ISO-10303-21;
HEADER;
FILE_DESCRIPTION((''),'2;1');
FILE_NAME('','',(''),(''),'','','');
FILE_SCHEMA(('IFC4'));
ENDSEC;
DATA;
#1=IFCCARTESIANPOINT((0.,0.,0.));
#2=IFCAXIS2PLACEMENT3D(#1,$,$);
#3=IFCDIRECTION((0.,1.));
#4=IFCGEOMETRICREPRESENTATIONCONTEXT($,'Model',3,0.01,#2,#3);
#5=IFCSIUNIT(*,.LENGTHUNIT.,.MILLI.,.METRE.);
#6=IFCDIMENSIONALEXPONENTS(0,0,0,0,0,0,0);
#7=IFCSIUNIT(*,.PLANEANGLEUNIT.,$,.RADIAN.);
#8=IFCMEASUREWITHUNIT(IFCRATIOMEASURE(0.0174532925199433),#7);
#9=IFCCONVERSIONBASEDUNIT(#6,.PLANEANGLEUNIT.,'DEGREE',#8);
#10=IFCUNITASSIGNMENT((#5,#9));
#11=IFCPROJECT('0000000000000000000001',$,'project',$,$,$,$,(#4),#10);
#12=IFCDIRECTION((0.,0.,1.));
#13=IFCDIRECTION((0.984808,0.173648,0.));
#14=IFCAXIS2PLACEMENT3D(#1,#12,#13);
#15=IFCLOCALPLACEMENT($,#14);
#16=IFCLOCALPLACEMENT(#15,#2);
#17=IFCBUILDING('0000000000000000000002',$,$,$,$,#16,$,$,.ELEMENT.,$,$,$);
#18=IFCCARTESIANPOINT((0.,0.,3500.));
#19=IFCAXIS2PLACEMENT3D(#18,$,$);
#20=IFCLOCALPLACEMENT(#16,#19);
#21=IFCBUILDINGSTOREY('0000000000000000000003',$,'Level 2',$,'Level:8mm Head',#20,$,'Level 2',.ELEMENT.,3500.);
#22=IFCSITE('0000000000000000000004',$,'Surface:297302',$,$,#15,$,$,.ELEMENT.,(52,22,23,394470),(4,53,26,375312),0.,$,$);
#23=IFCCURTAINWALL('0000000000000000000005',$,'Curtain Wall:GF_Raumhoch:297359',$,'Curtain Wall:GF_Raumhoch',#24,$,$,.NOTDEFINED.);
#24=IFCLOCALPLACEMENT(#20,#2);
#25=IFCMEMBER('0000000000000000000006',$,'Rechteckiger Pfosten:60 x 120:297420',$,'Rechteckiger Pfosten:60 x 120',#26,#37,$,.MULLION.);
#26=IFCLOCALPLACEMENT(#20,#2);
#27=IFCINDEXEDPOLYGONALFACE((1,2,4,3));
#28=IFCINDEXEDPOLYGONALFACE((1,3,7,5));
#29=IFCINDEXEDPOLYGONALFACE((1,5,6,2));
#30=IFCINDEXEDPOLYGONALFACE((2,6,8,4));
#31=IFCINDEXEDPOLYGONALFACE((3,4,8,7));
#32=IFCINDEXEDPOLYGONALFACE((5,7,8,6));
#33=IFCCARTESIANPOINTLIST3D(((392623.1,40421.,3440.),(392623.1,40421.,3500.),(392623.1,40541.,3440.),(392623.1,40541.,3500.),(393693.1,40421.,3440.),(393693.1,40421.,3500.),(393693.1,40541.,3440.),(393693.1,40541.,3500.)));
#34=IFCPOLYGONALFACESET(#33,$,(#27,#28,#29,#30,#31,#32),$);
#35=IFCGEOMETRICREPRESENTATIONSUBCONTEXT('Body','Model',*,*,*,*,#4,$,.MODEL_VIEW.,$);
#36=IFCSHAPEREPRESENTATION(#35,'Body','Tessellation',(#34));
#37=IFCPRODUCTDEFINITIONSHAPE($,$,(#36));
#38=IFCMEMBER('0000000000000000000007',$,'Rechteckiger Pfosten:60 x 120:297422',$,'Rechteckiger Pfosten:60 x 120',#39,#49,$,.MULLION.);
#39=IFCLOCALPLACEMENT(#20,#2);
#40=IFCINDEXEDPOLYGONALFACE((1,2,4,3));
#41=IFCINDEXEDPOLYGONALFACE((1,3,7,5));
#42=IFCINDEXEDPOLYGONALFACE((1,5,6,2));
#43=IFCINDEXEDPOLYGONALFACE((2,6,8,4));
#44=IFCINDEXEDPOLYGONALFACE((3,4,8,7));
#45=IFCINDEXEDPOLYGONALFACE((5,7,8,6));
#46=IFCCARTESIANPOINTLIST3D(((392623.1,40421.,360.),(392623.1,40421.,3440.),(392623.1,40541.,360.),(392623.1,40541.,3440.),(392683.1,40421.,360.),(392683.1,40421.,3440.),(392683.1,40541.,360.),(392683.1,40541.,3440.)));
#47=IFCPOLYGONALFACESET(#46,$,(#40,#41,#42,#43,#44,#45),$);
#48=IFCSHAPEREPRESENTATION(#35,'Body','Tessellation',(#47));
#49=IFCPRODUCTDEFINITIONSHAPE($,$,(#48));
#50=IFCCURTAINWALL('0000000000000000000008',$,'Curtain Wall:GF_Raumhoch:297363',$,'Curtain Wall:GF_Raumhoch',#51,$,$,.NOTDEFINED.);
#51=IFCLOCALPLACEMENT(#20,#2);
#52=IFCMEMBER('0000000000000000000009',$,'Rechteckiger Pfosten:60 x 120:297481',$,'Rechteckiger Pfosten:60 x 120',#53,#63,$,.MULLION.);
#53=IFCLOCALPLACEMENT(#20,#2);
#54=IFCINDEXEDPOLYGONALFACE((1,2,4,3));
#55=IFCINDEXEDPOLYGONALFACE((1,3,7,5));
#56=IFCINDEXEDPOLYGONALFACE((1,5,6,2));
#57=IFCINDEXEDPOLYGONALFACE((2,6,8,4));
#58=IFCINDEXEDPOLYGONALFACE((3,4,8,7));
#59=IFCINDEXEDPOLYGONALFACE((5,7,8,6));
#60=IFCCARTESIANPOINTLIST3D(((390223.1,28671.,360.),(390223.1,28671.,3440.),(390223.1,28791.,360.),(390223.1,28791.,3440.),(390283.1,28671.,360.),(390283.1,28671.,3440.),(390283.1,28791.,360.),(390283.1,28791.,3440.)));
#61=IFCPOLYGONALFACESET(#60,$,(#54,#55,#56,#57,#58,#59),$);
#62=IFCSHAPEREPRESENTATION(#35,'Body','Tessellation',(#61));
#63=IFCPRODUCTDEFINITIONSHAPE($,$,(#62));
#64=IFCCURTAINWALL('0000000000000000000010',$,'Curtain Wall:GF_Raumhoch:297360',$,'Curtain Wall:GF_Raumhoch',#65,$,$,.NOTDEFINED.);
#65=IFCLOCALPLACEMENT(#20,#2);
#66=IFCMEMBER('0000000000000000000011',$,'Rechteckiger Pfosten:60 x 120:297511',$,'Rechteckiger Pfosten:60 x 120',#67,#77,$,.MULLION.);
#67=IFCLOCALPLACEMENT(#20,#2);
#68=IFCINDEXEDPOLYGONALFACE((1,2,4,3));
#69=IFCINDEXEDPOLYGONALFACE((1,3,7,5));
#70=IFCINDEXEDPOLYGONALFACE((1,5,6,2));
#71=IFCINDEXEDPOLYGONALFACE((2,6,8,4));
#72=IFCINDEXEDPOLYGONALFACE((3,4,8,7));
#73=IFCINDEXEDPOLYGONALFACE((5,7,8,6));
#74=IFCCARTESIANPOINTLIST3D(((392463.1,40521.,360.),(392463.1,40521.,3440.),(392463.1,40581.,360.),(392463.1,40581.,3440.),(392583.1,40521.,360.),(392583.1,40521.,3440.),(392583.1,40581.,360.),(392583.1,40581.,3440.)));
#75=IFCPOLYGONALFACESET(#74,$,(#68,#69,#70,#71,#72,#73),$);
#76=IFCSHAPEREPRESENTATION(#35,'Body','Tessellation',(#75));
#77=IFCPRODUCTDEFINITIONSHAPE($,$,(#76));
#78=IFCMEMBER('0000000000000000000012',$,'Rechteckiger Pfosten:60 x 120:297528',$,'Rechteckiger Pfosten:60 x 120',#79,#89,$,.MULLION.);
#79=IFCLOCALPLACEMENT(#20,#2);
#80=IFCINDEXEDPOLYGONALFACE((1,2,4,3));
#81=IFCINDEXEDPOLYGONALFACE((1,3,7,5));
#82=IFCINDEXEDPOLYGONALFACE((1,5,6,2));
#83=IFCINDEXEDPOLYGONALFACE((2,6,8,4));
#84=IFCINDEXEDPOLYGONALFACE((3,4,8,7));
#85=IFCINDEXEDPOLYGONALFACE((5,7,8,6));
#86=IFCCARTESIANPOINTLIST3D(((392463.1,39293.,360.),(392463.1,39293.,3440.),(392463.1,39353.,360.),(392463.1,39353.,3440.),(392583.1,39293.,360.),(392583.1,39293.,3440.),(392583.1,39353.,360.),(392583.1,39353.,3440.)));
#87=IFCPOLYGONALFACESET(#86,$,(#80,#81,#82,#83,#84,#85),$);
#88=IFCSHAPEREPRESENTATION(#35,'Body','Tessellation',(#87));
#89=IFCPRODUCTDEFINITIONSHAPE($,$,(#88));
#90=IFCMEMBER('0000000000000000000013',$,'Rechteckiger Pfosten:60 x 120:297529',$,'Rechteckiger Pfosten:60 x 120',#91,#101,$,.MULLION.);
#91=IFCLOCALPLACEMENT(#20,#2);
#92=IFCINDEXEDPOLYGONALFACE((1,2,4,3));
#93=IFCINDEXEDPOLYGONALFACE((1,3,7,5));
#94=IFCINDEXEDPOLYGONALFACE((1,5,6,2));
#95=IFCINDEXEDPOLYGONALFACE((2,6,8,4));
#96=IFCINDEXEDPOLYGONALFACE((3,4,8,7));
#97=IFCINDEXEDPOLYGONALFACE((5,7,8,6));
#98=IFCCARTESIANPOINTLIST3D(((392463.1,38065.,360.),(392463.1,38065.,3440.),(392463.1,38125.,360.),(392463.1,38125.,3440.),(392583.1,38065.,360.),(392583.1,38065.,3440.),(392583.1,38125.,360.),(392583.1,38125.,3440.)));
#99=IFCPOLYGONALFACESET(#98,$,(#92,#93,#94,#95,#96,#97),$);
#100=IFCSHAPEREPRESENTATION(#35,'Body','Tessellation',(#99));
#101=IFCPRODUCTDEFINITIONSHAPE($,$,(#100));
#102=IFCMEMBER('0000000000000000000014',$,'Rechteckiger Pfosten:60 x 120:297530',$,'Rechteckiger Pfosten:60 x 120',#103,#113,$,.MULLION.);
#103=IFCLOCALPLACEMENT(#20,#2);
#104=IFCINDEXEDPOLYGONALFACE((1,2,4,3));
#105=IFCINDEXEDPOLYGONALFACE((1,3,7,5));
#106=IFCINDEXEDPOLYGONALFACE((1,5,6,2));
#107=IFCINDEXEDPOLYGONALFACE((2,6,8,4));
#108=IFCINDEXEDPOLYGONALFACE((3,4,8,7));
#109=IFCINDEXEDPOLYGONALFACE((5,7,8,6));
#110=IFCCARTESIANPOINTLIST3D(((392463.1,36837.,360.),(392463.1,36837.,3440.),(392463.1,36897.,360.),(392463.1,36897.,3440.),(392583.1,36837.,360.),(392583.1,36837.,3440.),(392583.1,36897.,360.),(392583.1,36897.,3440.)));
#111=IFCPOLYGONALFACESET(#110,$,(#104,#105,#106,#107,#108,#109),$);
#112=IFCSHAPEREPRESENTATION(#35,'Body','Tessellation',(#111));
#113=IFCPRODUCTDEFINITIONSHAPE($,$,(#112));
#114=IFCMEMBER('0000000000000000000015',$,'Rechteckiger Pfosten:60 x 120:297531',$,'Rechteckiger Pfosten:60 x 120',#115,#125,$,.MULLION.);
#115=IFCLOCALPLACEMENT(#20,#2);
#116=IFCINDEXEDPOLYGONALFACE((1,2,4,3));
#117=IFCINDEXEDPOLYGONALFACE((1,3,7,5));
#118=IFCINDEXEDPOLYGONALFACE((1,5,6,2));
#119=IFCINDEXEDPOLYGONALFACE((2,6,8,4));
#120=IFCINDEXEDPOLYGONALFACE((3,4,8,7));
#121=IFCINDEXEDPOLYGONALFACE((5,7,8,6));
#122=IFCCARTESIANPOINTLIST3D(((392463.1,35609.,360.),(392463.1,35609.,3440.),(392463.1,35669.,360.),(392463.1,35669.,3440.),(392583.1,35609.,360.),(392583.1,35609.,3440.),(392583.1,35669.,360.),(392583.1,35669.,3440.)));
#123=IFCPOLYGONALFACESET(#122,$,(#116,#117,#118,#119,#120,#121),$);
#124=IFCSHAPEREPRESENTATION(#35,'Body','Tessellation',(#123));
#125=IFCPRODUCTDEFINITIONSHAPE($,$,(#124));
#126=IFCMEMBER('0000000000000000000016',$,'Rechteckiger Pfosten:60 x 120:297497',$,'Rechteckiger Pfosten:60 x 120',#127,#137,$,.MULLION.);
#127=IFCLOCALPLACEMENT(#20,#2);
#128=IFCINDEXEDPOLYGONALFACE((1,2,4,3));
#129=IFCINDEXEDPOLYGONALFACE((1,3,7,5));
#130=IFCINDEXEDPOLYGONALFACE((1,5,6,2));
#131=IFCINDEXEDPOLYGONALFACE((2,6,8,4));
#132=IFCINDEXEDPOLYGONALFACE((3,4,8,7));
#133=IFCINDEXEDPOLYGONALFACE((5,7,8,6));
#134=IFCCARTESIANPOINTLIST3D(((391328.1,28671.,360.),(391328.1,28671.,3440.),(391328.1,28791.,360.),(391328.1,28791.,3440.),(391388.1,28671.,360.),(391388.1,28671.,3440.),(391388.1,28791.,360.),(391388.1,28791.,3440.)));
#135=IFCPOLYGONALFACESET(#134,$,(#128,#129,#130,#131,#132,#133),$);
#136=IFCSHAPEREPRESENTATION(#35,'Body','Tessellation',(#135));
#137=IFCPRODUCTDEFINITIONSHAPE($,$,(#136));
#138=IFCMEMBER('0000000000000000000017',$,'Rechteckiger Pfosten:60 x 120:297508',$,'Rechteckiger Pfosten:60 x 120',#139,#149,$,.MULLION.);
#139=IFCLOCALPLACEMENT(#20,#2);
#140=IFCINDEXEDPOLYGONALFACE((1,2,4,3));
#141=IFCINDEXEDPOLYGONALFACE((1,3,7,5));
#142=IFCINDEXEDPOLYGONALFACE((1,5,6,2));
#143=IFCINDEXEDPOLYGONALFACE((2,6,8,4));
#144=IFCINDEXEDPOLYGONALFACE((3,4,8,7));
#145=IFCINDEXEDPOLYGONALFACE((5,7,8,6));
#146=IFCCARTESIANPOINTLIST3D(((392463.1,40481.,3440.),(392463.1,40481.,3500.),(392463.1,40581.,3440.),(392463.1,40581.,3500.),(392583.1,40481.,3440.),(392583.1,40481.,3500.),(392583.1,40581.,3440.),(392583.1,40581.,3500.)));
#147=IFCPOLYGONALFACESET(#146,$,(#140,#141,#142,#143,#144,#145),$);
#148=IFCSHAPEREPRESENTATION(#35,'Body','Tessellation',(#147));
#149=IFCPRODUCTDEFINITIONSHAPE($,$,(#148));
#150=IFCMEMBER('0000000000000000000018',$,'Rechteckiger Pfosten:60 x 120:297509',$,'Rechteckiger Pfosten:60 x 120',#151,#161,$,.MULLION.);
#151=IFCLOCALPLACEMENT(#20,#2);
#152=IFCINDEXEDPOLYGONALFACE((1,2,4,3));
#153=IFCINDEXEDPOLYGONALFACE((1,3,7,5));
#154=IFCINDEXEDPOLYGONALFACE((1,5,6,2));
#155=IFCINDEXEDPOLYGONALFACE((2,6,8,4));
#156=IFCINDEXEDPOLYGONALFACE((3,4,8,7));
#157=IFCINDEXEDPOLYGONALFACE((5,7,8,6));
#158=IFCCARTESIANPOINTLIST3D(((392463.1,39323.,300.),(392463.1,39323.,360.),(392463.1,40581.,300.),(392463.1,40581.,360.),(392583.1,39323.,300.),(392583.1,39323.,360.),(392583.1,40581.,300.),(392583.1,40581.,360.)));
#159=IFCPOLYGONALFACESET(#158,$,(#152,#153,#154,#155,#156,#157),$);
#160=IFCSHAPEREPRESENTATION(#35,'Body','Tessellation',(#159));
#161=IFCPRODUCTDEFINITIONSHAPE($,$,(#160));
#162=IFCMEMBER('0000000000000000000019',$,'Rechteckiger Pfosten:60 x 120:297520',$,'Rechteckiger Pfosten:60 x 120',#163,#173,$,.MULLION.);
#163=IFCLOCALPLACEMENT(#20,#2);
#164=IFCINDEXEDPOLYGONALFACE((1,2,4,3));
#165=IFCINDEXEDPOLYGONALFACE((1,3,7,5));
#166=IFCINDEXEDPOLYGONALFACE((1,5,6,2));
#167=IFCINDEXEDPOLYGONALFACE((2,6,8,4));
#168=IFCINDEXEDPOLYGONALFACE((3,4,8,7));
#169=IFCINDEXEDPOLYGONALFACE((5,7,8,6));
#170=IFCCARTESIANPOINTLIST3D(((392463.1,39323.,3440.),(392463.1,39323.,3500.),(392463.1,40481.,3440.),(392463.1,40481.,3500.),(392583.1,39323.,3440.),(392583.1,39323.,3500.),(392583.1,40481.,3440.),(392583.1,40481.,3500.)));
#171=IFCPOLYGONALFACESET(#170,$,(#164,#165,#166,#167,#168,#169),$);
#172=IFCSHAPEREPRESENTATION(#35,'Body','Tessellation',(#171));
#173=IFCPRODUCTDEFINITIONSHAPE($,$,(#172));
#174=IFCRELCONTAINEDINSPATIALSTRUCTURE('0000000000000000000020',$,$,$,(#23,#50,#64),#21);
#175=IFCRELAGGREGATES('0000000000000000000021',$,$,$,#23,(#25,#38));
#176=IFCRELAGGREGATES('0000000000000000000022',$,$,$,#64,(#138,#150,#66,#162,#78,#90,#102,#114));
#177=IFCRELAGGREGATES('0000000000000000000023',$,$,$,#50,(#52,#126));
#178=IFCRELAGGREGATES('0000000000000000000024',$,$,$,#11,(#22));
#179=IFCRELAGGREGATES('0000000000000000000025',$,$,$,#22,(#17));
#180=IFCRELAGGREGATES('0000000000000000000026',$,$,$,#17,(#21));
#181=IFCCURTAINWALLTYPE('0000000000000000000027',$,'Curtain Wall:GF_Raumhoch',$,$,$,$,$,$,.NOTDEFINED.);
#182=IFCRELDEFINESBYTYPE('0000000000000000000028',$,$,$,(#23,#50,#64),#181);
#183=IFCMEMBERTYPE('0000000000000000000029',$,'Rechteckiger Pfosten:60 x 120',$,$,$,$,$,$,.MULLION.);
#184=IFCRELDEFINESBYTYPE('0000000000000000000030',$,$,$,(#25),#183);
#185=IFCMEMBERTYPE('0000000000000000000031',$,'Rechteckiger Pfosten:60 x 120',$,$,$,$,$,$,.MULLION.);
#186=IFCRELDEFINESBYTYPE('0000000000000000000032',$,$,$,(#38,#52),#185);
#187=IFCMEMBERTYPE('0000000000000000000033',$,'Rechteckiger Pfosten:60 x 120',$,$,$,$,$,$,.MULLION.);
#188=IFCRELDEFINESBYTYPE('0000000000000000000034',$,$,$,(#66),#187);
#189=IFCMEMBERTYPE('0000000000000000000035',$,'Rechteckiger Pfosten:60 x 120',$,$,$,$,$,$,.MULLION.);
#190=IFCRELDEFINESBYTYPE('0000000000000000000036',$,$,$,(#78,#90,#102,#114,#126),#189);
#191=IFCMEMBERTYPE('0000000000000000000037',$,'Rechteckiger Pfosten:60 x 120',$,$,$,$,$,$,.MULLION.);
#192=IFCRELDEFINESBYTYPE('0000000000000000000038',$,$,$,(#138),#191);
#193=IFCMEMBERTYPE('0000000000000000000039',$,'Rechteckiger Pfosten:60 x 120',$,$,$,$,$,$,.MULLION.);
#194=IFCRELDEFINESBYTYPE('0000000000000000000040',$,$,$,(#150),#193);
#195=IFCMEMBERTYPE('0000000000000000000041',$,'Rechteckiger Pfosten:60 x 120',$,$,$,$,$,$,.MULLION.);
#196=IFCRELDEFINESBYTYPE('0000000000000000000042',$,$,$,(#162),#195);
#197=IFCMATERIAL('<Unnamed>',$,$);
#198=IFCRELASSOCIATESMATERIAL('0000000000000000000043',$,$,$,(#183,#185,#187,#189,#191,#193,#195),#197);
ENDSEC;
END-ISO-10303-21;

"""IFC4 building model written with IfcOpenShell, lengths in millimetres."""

from ifc_helpers import new_model, entity, si_unit, converted_unit, direction, frame, origin, place, context, subcontext, project, spatial, indexed_curve, outline, extrude, source, transform, mapped, material, type_object, type_shapes, element, aggregate, save


model = new_model("IFC4")

# Units and contexts
model_context = context("Model", 3, precision=0.01, world=origin(), true_north=direction((0.0, 1.0)))
body_context = subcontext(model_context, "Body", "Model", "MODEL_VIEW")
ifc_project = project(units=[si_unit("LENGTHUNIT", "METRE", prefix="MILLI"), converted_unit("PLANEANGLEUNIT", "DEGREE", entity("IfcRatioMeasure", 0.0174532925199433), si_unit("PLANEANGLEUNIT", "RADIAN"), dimensions=[0, 0, 0, 0, 0, 0, 0])], contexts=[model_context])

# Site, building, storey
site_placement = place(None, frame((0.0, 0.0, 0.0), z_axis=(0.0, 0.0, 1.0), x_axis=(0.984808, 0.173648, 0.0)))
site = spatial("IfcSite", under=ifc_project, at=site_placement, Name="Surface:297302", CompositionType="ELEMENT", RefLatitude=(52, 22, 23, 394470), RefLongitude=(4, 53, 26, 375312), RefElevation=0.0)
building_placement = place(site_placement, origin())
building = spatial("IfcBuilding", under=site, at=building_placement, CompositionType="ELEMENT")
storey_placement = place(building_placement, frame((0.0, 0.0, 3500.0)))
storey = spatial("IfcBuildingStorey", under=building, at=storey_placement, Name="Level 2", ObjectType="Level:8mm Head", LongName="Level 2", CompositionType="ELEMENT", Elevation=3500.0)

# Curtain wall, members
curtain_wall_type = type_object("IfcCurtainWallType", Name="Curtain Wall:GF_Raumhoch", PredefinedType="NOTDEFINED")
curtain_wall_1_placement = place(storey_placement, frame((0.0, 0.0, -3500.0)))
curtain_wall_1 = element("IfcCurtainWall", 1, at=curtain_wall_1_placement, inside=storey, type_object=curtain_wall_type, Name="Curtain Wall:GF_Raumhoch:297359", ObjectType="Curtain Wall:GF_Raumhoch", PredefinedType="NOTDEFINED")
ifc_material_1 = material(Name="<Unnamed>")
member_type_1 = type_object("IfcMemberType", Name="Rechteckiger Pfosten:60 x 120", PredefinedType="MULLION", material=ifc_material_1)
shared_shape_1 = source(origin(), body_context, "Body", "SweptSolid", [
    extrude(outline(indexed_curve([(-60.0, -30.0), (60.0, -30.0), (60.0, 30.0), (-60.0, 30.0), (-60.0, -30.0)], self_intersect=False)), frame((-30.0, 0.0, -1070.0), z_axis=(0.0, 0.0, 1.0), x_axis=(0.0, -1.0, 0.0)), (0.0, 0.0, 1.0), 1070.0),
])
type_shapes(member_type_1, [shared_shape_1])
member_1_placement = place(curtain_wall_1_placement, frame((392623.1, 40481.0, 7000.0), z_axis=(-1.0, 0.0, 0.0), x_axis=(0.0, 0.0, 1.0)))
member_1 = element("IfcMember", 2, at=member_1_placement, type_object=member_type_1, Name="Rechteckiger Pfosten:60 x 120:297420", ObjectType="Rechteckiger Pfosten:60 x 120", PredefinedType="MULLION", context=body_context, shape_type="MappedRepresentation", body=[
    mapped(shared_shape_1, transform((0.0, 0.0, 0.0), scale=1.0)),
])
member_type_2 = type_object("IfcMemberType", Name="Rechteckiger Pfosten:60 x 120", PredefinedType="MULLION", material=ifc_material_1)
shared_shape_2 = source(origin(), body_context, "Body", "SweptSolid", [
    extrude(outline(indexed_curve([(-60.0, -30.0), (60.0, -30.0), (60.0, 30.0), (-60.0, 30.0), (-60.0, -30.0)], self_intersect=False)), frame((-30.0, 0.0, -3080.0), z_axis=(0.0, 0.0, 1.0), x_axis=(0.0, -1.0, 0.0)), (0.0, 0.0, 1.0), 3080.0),
])
type_shapes(member_type_2, [shared_shape_2])
member_2_placement = place(curtain_wall_1_placement, frame((392623.1, 40481.0, 3860.0), z_axis=(0.0, 0.0, -1.0), x_axis=(-1.0, 0.0, 0.0)))
member_2 = element("IfcMember", 3, at=member_2_placement, type_object=member_type_2, Name="Rechteckiger Pfosten:60 x 120:297422", ObjectType="Rechteckiger Pfosten:60 x 120", PredefinedType="MULLION", context=body_context, shape_type="MappedRepresentation", body=[
    mapped(shared_shape_2, transform((0.0, 0.0, 0.0), scale=1.0)),
])

# Curtain wall, member
curtain_wall_2_placement = place(storey_placement, frame((0.0, 0.0, -3500.0)))
curtain_wall_2 = element("IfcCurtainWall", 4, at=curtain_wall_2_placement, inside=storey, type_object=curtain_wall_type, Name="Curtain Wall:GF_Raumhoch:297363", ObjectType="Curtain Wall:GF_Raumhoch", PredefinedType="NOTDEFINED")
member_3_placement = place(curtain_wall_2_placement, frame((390223.1, 28731.0, 3860.0), z_axis=(0.0, 0.0, -1.0), x_axis=(-1.0, 0.0, 0.0)))
member_3 = element("IfcMember", 5, at=member_3_placement, type_object=member_type_2, Name="Rechteckiger Pfosten:60 x 120:297481", ObjectType="Rechteckiger Pfosten:60 x 120", PredefinedType="MULLION", context=body_context, shape_type="MappedRepresentation", body=[
    mapped(shared_shape_2, transform((0.0, 0.0, 0.0), scale=1.0)),
])

# Curtain wall, members
curtain_wall_3_placement = place(storey_placement, frame((0.0, 0.0, -3500.0)))
curtain_wall_3 = element("IfcCurtainWall", 6, at=curtain_wall_3_placement, inside=storey, type_object=curtain_wall_type, Name="Curtain Wall:GF_Raumhoch:297360", ObjectType="Curtain Wall:GF_Raumhoch", PredefinedType="NOTDEFINED")
member_type_3 = type_object("IfcMemberType", Name="Rechteckiger Pfosten:60 x 120", PredefinedType="MULLION", material=ifc_material_1)
shared_shape_3 = source(origin(), body_context, "Body", "SweptSolid", [
    extrude(outline(indexed_curve([(-60.0, -30.0), (60.0, -30.0), (60.0, 30.0), (-60.0, 30.0), (-60.0, -30.0)], self_intersect=False)), frame((-30.0, 0.0, -3080.0), z_axis=(0.0, 0.0, 1.0), x_axis=(0.0, -1.0, 0.0)), (0.0, 0.0, 1.0), 3080.0),
])
type_shapes(member_type_3, [shared_shape_3])
member_4_placement = place(curtain_wall_3_placement, frame((392523.1, 40581.0, 6940.0), z_axis=(0.0, 0.0, 1.0), x_axis=(0.0, 1.0, 0.0)))
member_4 = element("IfcMember", 7, at=member_4_placement, type_object=member_type_3, Name="Rechteckiger Pfosten:60 x 120:297511", ObjectType="Rechteckiger Pfosten:60 x 120", PredefinedType="MULLION", context=body_context, shape_type="MappedRepresentation", body=[
    mapped(shared_shape_3, transform((0.0, 0.0, 0.0), scale=1.0)),
])
member_type_4 = type_object("IfcMemberType", Name="Rechteckiger Pfosten:60 x 120", PredefinedType="MULLION", material=ifc_material_1)
shared_shape_4 = source(origin(), body_context, "Body", "SweptSolid", [
    extrude(outline(indexed_curve([(-60.0, -30.0), (60.0, -30.0), (60.0, 30.0), (-60.0, 30.0), (-60.0, -30.0)], self_intersect=False)), frame((0.0, 0.0, -3080.0), z_axis=(0.0, 0.0, 1.0), x_axis=(0.0, -1.0, 0.0)), (0.0, 0.0, 1.0), 3080.0),
])
type_shapes(member_type_4, [shared_shape_4])
member_5_placement = place(curtain_wall_3_placement, frame((392523.1, 39323.0, 3860.0), z_axis=(0.0, 0.0, -1.0), x_axis=(0.0, -1.0, 0.0)))
member_5 = element("IfcMember", 8, at=member_5_placement, type_object=member_type_4, Name="Rechteckiger Pfosten:60 x 120:297528", ObjectType="Rechteckiger Pfosten:60 x 120", PredefinedType="MULLION", context=body_context, shape_type="MappedRepresentation", body=[
    mapped(shared_shape_4, transform((0.0, 0.0, 0.0), scale=1.0)),
])
member_6_placement = place(curtain_wall_3_placement, frame((392523.1, 38095.0, 3860.0), z_axis=(0.0, 0.0, -1.0), x_axis=(0.0, -1.0, 0.0)))
member_6 = element("IfcMember", 9, at=member_6_placement, type_object=member_type_4, Name="Rechteckiger Pfosten:60 x 120:297529", ObjectType="Rechteckiger Pfosten:60 x 120", PredefinedType="MULLION", context=body_context, shape_type="MappedRepresentation", body=[
    mapped(shared_shape_4, transform((0.0, 0.0, 0.0), scale=1.0)),
])
member_7_placement = place(curtain_wall_3_placement, frame((392523.1, 36867.0, 3860.0), z_axis=(0.0, 0.0, -1.0), x_axis=(0.0, -1.0, 0.0)))
member_7 = element("IfcMember", 10, at=member_7_placement, type_object=member_type_4, Name="Rechteckiger Pfosten:60 x 120:297530", ObjectType="Rechteckiger Pfosten:60 x 120", PredefinedType="MULLION", context=body_context, shape_type="MappedRepresentation", body=[
    mapped(shared_shape_4, transform((0.0, 0.0, 0.0), scale=1.0)),
])
member_8_placement = place(curtain_wall_3_placement, frame((392523.1, 35639.0, 3860.0), z_axis=(0.0, 0.0, -1.0), x_axis=(0.0, -1.0, 0.0)))
member_8 = element("IfcMember", 11, at=member_8_placement, type_object=member_type_4, Name="Rechteckiger Pfosten:60 x 120:297531", ObjectType="Rechteckiger Pfosten:60 x 120", PredefinedType="MULLION", context=body_context, shape_type="MappedRepresentation", body=[
    mapped(shared_shape_4, transform((0.0, 0.0, 0.0), scale=1.0)),
])

# Members
member_9_placement = place(curtain_wall_2_placement, frame((391358.1, 28731.0, 3860.0), z_axis=(0.0, 0.0, -1.0), x_axis=(-1.0, 0.0, 0.0)))
member_9 = element("IfcMember", 12, at=member_9_placement, type_object=member_type_4, Name="Rechteckiger Pfosten:60 x 120:297497", ObjectType="Rechteckiger Pfosten:60 x 120", PredefinedType="MULLION", context=body_context, shape_type="MappedRepresentation", body=[
    mapped(shared_shape_4, transform((0.0, 0.0, 0.0), scale=1.0)),
])
member_type_5 = type_object("IfcMemberType", Name="Rechteckiger Pfosten:60 x 120", PredefinedType="MULLION", material=ifc_material_1)
shared_shape_5 = source(origin(), body_context, "Body", "SweptSolid", [
    extrude(outline(indexed_curve([(-60.0, -30.0), (60.0, -30.0), (60.0, 30.0), (-60.0, 30.0), (-60.0, -30.0)], self_intersect=False)), frame((-30.0, 0.0, -100.0), z_axis=(0.0, 0.0, 1.0), x_axis=(0.0, -1.0, 0.0)), (0.0, 0.0, 1.0), 100.0),
])
type_shapes(member_type_5, [shared_shape_5])
member_10_placement = place(curtain_wall_3_placement, frame((392523.1, 40481.0, 7000.0), z_axis=(0.0, -1.0, 0.0), x_axis=(0.0, 0.0, 1.0)))
member_10 = element("IfcMember", 13, at=member_10_placement, type_object=member_type_5, Name="Rechteckiger Pfosten:60 x 120:297508", ObjectType="Rechteckiger Pfosten:60 x 120", PredefinedType="MULLION", context=body_context, shape_type="MappedRepresentation", body=[
    mapped(shared_shape_5, transform((0.0, 0.0, 0.0), scale=1.0)),
])
member_type_6 = type_object("IfcMemberType", Name="Rechteckiger Pfosten:60 x 120", PredefinedType="MULLION", material=ifc_material_1)
shared_shape_6 = source(origin(), body_context, "Body", "SweptSolid", [
    extrude(outline(indexed_curve([(-60.0, -30.0), (60.0, -30.0), (60.0, 30.0), (-60.0, 30.0), (-60.0, -30.0)], self_intersect=False)), frame((-30.0, 0.0, -1258.0), z_axis=(0.0, 0.0, 1.0), x_axis=(0.0, -1.0, 0.0)), (0.0, 0.0, 1.0), 1258.0),
])
type_shapes(member_type_6, [shared_shape_6])
member_11_placement = place(curtain_wall_3_placement, frame((392523.1, 40581.0, 3800.0), z_axis=(0.0, 1.0, 0.0), x_axis=(0.0, 0.0, -1.0)))
member_11 = element("IfcMember", 14, at=member_11_placement, type_object=member_type_6, Name="Rechteckiger Pfosten:60 x 120:297509", ObjectType="Rechteckiger Pfosten:60 x 120", PredefinedType="MULLION", context=body_context, shape_type="MappedRepresentation", body=[
    mapped(shared_shape_6, transform((0.0, 0.0, 0.0), scale=1.0)),
])
member_type_7 = type_object("IfcMemberType", Name="Rechteckiger Pfosten:60 x 120", PredefinedType="MULLION", material=ifc_material_1)
shared_shape_7 = source(origin(), body_context, "Body", "SweptSolid", [
    extrude(outline(indexed_curve([(-60.0, -30.0), (60.0, -30.0), (60.0, 30.0), (-60.0, 30.0), (-60.0, -30.0)], self_intersect=False)), frame((-30.0, 0.0, -1158.0), z_axis=(0.0, 0.0, 1.0), x_axis=(0.0, -1.0, 0.0)), (0.0, 0.0, 1.0), 1158.0),
])
type_shapes(member_type_7, [shared_shape_7])
member_12_placement = place(curtain_wall_3_placement, frame((392523.1, 39323.0, 7000.0), z_axis=(0.0, -1.0, 0.0), x_axis=(0.0, 0.0, 1.0)))
member_12 = element("IfcMember", 15, at=member_12_placement, type_object=member_type_7, Name="Rechteckiger Pfosten:60 x 120:297520", ObjectType="Rechteckiger Pfosten:60 x 120", PredefinedType="MULLION", context=body_context, shape_type="MappedRepresentation", body=[
    mapped(shared_shape_7, transform((0.0, 0.0, 0.0), scale=1.0)),
])

aggregate(curtain_wall_1, [member_1, member_2])
aggregate(curtain_wall_3, [member_10, member_11, member_4, member_12, member_5, member_6, member_7, member_8])
aggregate(curtain_wall_2, [member_3, member_9])

save(model, "model.ifc")
